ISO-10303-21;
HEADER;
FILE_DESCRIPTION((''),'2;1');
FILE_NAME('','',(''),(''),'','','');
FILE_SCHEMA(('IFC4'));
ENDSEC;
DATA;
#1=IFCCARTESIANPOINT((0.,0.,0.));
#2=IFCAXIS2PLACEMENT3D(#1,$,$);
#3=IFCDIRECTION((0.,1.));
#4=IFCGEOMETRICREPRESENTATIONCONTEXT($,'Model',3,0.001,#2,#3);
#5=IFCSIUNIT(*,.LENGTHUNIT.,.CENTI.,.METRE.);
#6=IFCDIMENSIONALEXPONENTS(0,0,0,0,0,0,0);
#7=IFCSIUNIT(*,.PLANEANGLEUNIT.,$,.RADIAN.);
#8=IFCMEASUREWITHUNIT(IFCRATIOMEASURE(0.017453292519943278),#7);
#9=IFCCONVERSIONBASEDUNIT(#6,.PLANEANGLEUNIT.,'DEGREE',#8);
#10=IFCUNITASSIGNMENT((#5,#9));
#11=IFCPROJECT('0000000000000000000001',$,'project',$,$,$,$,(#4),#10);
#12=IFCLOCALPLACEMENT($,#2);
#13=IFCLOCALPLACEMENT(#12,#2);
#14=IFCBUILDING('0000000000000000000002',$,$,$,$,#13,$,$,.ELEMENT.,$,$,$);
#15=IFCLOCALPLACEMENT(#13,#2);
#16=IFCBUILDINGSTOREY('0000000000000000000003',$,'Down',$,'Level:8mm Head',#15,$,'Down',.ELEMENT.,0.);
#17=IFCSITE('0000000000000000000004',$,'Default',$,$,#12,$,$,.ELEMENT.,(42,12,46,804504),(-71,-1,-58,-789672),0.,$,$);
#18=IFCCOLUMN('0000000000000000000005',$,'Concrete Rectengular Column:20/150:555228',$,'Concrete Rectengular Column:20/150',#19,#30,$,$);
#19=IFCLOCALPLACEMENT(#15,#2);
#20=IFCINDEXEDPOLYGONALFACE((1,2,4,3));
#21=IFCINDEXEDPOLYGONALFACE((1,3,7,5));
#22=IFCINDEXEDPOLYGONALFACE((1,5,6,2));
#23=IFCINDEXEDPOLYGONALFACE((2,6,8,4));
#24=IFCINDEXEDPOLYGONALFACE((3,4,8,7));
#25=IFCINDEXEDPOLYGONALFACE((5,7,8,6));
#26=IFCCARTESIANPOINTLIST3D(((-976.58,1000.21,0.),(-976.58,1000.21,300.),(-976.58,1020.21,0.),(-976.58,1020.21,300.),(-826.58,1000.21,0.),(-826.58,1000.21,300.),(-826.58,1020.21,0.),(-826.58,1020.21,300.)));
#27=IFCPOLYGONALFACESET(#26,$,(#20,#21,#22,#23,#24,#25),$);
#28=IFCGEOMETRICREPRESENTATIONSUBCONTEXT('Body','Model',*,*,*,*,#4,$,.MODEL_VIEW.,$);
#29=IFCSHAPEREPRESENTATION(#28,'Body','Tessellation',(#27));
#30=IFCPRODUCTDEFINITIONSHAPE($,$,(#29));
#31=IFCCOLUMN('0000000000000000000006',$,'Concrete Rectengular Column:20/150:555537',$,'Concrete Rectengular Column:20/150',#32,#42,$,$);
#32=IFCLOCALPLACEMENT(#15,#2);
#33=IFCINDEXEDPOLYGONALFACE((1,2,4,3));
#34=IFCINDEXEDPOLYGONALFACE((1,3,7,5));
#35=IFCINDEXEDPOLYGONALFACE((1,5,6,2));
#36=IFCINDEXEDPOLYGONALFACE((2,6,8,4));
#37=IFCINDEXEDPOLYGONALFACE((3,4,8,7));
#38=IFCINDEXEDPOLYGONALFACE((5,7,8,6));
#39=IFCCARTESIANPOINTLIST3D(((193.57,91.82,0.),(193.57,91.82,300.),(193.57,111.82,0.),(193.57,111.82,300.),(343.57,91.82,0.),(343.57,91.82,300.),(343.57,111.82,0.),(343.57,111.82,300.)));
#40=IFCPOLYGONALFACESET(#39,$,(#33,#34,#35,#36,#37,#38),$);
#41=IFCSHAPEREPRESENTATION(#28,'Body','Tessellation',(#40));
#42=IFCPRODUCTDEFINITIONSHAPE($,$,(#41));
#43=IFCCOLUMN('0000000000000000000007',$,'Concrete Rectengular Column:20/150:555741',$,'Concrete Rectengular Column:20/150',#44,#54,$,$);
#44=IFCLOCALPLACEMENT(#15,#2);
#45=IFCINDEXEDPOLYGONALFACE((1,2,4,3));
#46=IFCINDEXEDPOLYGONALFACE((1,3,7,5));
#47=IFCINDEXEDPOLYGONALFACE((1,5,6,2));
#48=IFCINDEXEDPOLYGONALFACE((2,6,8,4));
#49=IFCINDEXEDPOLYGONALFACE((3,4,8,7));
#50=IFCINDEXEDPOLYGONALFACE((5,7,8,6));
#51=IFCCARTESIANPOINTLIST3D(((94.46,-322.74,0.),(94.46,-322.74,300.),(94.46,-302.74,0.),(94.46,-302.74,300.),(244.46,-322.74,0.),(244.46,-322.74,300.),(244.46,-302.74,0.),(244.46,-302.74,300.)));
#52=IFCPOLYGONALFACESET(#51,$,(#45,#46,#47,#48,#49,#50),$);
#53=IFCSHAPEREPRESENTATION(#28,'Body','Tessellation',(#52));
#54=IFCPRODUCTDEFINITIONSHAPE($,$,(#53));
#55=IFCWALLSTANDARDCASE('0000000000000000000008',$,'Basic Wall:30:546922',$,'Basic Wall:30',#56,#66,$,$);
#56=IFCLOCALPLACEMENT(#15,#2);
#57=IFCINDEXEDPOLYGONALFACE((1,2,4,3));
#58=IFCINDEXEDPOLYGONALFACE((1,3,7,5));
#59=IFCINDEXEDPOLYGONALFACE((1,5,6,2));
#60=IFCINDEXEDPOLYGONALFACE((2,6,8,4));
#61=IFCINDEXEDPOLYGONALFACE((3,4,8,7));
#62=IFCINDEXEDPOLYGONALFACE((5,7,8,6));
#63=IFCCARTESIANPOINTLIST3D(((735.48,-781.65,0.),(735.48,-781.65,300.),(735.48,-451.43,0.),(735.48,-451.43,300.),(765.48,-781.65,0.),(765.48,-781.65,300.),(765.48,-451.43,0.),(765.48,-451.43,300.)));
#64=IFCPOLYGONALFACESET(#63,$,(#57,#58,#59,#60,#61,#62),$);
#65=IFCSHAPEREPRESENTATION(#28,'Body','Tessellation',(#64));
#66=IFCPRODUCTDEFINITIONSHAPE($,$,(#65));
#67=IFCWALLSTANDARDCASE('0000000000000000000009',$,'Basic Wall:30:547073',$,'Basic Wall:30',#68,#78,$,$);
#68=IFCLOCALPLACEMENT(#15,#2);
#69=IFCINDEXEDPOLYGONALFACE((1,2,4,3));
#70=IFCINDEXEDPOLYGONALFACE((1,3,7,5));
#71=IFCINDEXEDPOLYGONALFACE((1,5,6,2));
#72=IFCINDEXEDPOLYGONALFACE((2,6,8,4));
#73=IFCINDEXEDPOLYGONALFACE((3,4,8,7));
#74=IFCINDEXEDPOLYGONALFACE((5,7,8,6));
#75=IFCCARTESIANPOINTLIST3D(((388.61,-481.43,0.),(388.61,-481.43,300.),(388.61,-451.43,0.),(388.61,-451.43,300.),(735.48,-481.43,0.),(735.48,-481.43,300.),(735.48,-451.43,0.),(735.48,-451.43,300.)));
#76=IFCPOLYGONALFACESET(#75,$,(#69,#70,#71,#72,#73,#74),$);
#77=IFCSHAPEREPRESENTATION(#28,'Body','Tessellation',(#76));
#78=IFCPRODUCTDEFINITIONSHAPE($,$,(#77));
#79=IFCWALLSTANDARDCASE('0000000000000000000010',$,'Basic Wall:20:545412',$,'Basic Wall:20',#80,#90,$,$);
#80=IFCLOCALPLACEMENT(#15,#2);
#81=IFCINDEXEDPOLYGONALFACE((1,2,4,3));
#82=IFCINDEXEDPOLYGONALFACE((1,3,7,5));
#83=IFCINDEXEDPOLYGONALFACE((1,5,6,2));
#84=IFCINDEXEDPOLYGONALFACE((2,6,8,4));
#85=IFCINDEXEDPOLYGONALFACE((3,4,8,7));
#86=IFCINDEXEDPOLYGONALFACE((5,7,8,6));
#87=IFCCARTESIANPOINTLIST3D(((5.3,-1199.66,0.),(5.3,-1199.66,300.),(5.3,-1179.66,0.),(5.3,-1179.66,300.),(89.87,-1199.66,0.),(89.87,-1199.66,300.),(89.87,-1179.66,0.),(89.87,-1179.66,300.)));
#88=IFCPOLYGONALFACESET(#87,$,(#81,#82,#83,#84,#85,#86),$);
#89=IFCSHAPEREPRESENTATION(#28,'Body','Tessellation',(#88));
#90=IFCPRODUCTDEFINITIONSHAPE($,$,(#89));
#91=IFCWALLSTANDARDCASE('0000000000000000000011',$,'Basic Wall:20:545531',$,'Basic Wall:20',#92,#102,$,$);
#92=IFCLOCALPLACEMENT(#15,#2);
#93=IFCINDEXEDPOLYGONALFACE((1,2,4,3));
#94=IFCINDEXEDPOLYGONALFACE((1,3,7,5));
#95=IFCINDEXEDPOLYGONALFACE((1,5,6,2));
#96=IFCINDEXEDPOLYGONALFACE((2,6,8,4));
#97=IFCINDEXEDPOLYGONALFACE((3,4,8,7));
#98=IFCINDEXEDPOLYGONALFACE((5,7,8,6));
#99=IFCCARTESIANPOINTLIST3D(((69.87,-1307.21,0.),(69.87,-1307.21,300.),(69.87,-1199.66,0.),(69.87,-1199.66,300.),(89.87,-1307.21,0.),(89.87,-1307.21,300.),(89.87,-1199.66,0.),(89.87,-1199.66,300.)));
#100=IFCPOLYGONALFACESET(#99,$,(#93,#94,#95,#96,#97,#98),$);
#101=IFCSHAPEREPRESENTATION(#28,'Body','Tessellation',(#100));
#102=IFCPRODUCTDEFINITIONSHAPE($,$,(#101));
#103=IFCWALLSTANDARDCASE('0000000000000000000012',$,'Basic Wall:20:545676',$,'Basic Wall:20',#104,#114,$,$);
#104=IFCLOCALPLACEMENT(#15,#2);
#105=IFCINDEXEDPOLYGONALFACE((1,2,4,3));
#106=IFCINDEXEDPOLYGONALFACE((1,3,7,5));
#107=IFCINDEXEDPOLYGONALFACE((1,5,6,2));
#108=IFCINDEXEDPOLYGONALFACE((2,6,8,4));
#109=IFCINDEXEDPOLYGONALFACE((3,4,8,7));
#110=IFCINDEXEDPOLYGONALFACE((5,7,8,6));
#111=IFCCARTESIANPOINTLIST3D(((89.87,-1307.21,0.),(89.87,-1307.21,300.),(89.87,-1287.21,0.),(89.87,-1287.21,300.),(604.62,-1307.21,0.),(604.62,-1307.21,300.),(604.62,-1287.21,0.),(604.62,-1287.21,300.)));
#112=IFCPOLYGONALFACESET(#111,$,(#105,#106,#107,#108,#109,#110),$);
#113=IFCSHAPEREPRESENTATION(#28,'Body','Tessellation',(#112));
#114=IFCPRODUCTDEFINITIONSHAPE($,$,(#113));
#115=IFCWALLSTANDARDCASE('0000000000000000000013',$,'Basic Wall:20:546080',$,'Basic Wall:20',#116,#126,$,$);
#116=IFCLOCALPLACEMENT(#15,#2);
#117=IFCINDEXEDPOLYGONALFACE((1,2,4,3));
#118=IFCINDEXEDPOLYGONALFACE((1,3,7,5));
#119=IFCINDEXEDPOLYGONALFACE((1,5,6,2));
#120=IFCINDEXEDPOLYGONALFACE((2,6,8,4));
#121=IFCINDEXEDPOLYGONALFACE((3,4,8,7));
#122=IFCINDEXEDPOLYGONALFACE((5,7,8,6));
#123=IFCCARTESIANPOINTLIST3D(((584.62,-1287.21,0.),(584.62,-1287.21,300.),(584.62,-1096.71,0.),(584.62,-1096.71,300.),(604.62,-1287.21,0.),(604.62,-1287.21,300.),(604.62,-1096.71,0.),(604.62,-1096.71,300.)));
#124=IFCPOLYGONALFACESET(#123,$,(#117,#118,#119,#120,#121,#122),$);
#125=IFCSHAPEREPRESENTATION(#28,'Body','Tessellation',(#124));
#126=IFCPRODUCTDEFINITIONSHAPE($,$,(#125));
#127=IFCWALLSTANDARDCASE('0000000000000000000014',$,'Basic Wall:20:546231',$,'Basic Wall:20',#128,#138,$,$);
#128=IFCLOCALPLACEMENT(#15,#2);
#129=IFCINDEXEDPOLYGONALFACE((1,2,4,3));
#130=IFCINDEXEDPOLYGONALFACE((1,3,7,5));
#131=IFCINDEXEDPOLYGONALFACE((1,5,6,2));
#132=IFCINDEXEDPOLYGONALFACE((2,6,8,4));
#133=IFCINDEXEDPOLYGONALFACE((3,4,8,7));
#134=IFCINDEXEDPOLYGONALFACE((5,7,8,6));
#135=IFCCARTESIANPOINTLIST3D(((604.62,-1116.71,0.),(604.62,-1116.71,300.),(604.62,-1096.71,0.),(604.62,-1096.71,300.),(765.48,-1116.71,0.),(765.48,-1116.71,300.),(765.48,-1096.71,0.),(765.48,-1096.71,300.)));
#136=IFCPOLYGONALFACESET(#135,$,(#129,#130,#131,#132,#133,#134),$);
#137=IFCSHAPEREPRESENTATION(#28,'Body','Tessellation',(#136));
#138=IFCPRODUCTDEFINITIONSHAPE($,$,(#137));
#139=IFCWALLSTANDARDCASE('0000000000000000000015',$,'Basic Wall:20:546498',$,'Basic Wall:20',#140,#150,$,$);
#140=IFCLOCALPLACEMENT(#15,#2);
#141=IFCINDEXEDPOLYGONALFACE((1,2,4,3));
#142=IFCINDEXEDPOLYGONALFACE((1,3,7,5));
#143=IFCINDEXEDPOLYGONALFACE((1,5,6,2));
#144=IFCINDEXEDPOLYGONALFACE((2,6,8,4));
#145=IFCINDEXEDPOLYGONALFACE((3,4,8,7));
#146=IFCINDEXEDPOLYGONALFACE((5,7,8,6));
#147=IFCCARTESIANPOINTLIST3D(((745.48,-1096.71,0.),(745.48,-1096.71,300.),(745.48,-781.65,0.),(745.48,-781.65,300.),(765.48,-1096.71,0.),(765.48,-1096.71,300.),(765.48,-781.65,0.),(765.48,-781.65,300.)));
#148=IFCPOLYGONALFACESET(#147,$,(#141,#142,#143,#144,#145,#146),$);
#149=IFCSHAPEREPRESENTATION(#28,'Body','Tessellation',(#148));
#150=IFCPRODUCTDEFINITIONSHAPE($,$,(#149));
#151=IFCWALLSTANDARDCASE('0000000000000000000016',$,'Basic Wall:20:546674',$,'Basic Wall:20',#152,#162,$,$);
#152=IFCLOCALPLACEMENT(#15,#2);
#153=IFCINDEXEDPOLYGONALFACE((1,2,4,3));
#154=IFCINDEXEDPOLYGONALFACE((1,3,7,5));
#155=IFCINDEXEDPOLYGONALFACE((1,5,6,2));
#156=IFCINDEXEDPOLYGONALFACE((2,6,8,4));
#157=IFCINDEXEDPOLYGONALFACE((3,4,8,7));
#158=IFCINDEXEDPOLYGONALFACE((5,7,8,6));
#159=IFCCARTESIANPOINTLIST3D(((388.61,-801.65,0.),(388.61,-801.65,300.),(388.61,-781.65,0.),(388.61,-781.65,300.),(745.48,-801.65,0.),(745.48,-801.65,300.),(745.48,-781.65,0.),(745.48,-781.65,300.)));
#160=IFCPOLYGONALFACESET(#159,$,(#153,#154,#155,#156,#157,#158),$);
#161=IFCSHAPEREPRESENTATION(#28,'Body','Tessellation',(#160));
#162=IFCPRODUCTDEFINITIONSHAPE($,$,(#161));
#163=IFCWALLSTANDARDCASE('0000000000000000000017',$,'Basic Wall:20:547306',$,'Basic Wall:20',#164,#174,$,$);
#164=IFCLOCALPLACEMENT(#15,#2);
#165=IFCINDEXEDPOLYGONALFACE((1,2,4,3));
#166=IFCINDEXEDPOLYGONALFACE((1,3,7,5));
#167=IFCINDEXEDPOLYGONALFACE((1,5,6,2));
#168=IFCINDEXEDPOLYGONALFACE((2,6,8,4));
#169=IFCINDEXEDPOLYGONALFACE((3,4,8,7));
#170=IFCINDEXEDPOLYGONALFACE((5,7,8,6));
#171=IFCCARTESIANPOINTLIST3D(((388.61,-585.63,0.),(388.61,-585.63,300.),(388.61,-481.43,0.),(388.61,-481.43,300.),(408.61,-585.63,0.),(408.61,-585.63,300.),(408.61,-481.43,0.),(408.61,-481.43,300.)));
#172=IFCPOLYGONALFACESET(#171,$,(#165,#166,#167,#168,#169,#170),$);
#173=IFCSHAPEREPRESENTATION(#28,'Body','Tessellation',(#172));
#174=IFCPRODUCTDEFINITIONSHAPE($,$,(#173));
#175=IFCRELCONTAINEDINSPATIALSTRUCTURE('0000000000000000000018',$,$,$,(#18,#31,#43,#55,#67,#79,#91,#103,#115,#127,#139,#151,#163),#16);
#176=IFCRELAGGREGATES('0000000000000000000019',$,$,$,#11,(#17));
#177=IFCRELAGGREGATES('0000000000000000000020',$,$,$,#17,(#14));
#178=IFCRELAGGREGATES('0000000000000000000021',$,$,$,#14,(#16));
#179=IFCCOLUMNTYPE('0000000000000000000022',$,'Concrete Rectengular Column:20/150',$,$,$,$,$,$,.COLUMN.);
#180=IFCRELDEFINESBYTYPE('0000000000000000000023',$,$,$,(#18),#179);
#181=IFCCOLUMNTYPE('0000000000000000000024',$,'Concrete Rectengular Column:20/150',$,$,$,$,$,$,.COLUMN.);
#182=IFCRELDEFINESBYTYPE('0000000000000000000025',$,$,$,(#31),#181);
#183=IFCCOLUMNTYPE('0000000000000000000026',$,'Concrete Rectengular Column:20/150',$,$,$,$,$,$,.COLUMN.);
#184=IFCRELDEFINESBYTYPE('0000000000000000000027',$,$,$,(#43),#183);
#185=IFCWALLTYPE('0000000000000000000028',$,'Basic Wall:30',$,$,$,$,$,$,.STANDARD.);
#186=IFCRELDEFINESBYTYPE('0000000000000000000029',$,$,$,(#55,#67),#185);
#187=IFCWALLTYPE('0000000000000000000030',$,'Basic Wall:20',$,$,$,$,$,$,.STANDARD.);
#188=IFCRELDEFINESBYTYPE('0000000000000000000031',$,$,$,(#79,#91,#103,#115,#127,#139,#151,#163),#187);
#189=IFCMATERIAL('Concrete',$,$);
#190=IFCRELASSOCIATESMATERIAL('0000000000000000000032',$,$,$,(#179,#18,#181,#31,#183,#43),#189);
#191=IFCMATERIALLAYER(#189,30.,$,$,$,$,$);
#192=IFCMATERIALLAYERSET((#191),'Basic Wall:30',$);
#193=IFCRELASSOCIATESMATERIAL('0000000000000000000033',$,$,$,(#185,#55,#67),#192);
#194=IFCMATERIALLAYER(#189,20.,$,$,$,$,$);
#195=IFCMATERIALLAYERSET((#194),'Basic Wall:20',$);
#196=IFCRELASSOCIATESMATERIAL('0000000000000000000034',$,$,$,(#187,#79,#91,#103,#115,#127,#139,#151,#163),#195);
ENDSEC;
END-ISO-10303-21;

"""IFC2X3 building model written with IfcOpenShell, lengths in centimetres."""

from ifc_helpers import new_model, entity, si_unit, converted_unit, direction, frame, frame_2d, origin, place, context, subcontext, project, spatial, rectangle, extrude, source, transform, mapped, material, layer, layer_set, layer_usage, type_object, type_shapes, element, save


model = new_model("IFC2X3")

# Units and contexts
model_context = context("Model", 3, precision=0.001, world=origin(), true_north=direction((0.0, 1.0)))
body_context = subcontext(model_context, "Body", "Model", "MODEL_VIEW")
ifc_project = project(units=[si_unit("LENGTHUNIT", "METRE", prefix="CENTI"), converted_unit("PLANEANGLEUNIT", "DEGREE", entity("IfcRatioMeasure", 0.017453292519943278), si_unit("PLANEANGLEUNIT", "RADIAN"), dimensions=[0, 0, 0, 0, 0, 0, 0])], contexts=[model_context])

# Site, building, storey
site_placement = place(None, origin())
site = spatial("IfcSite", under=ifc_project, at=site_placement, Name="Default", CompositionType="ELEMENT", RefLatitude=(42, 12, 46, 804504), RefLongitude=(-71, -1, -58, -789672), RefElevation=0.0)
building_placement = place(site_placement, origin())
building = spatial("IfcBuilding", under=site, at=building_placement, CompositionType="ELEMENT")
storey_placement = place(building_placement, origin())
storey = spatial("IfcBuildingStorey", under=building, at=storey_placement, Name="Down", ObjectType="Level:8mm Head", LongName="Down", CompositionType="ELEMENT", Elevation=0.0)

# Columns
ifc_material = material(Name="Concrete")
column_type_1 = type_object("IfcColumnType", Name="Concrete Rectengular Column:20/150", PredefinedType="COLUMN", material=ifc_material)
shared_shape_1 = source(origin(), body_context, "Body", "SweptSolid", [
    extrude(rectangle(XDim=20.0, YDim=150.0, at=frame_2d((0.0, 0.0), x_axis=(1.0, 0.0))), frame((-901.58, 1010.21, 0.0), z_axis=(0.0, 0.0, 1.0), x_axis=(0.0, -1.0, 0.0)), (0.0, 0.0, 1.0), 300.0),
])
type_shapes(column_type_1, [shared_shape_1])
column_1_placement = place(storey_placement, origin())
element("IfcColumn", 1, at=column_1_placement, inside=storey, type_object=column_type_1, material=ifc_material, Name="Concrete Rectengular Column:20/150:555228", ObjectType="Concrete Rectengular Column:20/150", context=body_context, shape_type="MappedRepresentation", body=[
    mapped(shared_shape_1, transform((0.0, 0.0, 0.0), scale=1.0)),
])
column_type_2 = type_object("IfcColumnType", Name="Concrete Rectengular Column:20/150", PredefinedType="COLUMN", material=ifc_material)
shared_shape_2 = source(origin(), body_context, "Body", "SweptSolid", [
    extrude(rectangle(XDim=20.0, YDim=150.0, at=frame_2d((0.0, 0.0), x_axis=(1.0, 0.0))), frame((268.57, 101.82, 0.0), z_axis=(0.0, 0.0, 1.0), x_axis=(0.0, -1.0, 0.0)), (0.0, 0.0, 1.0), 300.0),
])
type_shapes(column_type_2, [shared_shape_2])
column_2_placement = place(storey_placement, origin())
element("IfcColumn", 2, at=column_2_placement, inside=storey, type_object=column_type_2, material=ifc_material, Name="Concrete Rectengular Column:20/150:555537", ObjectType="Concrete Rectengular Column:20/150", context=body_context, shape_type="MappedRepresentation", body=[
    mapped(shared_shape_2, transform((0.0, 0.0, 0.0), scale=1.0)),
])
column_type_3 = type_object("IfcColumnType", Name="Concrete Rectengular Column:20/150", PredefinedType="COLUMN", material=ifc_material)
shared_shape_3 = source(origin(), body_context, "Body", "SweptSolid", [
    extrude(rectangle(XDim=20.0, YDim=150.0, at=frame_2d((0.0, 0.0), x_axis=(1.0, 0.0))), frame((169.46, -312.74, 0.0), z_axis=(0.0, 0.0, 1.0), x_axis=(0.0, -1.0, 0.0)), (0.0, 0.0, 1.0), 300.0),
])
type_shapes(column_type_3, [shared_shape_3])
column_3_placement = place(storey_placement, origin())
element("IfcColumn", 3, at=column_3_placement, inside=storey, type_object=column_type_3, material=ifc_material, Name="Concrete Rectengular Column:20/150:555741", ObjectType="Concrete Rectengular Column:20/150", context=body_context, shape_type="MappedRepresentation", body=[
    mapped(shared_shape_3, transform((0.0, 0.0, 0.0), scale=1.0)),
])

# Walls
ifc_layer_1 = layer(ifc_material, 30.0)
ifc_layer_set_1 = layer_set([ifc_layer_1], Name="Basic Wall:30")
ifc_layer_usage_1 = layer_usage(ifc_layer_set_1, "AXIS2", "POSITIVE", -15.0)
wall_type_1 = type_object("IfcWallType", Name="Basic Wall:30", PredefinedType="STANDARD", material=ifc_layer_set_1)
wall_1_placement = place(storey_placement, frame((750.48, -781.65, 0.0), z_axis=(0.0, 0.0, 1.0), x_axis=(0.0, 1.0, 0.0)))
element("IfcWallStandardCase", 4, at=wall_1_placement, inside=storey, type_object=wall_type_1, material=ifc_layer_usage_1, Name="Basic Wall:30:546922", ObjectType="Basic Wall:30", context=body_context, shape_type="SweptSolid", body=[
    extrude(rectangle(XDim=330.22, YDim=30.0, at=frame_2d((165.11, 0.0), x_axis=(-1.0, 0.0))), origin(), (0.0, 0.0, 1.0), 300.0),
])
ifc_layer_usage_2 = layer_usage(ifc_layer_set_1, "AXIS2", "POSITIVE", -15.0)
wall_2_placement = place(storey_placement, frame((735.48, -466.43, 0.0), z_axis=(0.0, 0.0, 1.0), x_axis=(-1.0, 0.0, 0.0)))
element("IfcWallStandardCase", 5, at=wall_2_placement, inside=storey, type_object=wall_type_1, material=ifc_layer_usage_2, Name="Basic Wall:30:547073", ObjectType="Basic Wall:30", context=body_context, shape_type="SweptSolid", body=[
    extrude(rectangle(XDim=346.87, YDim=30.0, at=frame_2d((173.44, 0.0), x_axis=(-1.0, 0.0))), origin(), (0.0, 0.0, 1.0), 300.0),
])
ifc_layer_2 = layer(ifc_material, 20.0)
ifc_layer_set_2 = layer_set([ifc_layer_2], Name="Basic Wall:20")
ifc_layer_usage_3 = layer_usage(ifc_layer_set_2, "AXIS2", "POSITIVE", -10.0)
wall_type_2 = type_object("IfcWallType", Name="Basic Wall:20", PredefinedType="STANDARD", material=ifc_layer_set_2)
wall_3_placement = place(storey_placement, frame((5.3, -1189.66, 0.0)))
element("IfcWallStandardCase", 6, at=wall_3_placement, inside=storey, type_object=wall_type_2, material=ifc_layer_usage_3, Name="Basic Wall:20:545412", ObjectType="Basic Wall:20", context=body_context, shape_type="SweptSolid", body=[
    extrude(rectangle(XDim=84.57, YDim=20.0, at=frame_2d((42.28, 0.0), x_axis=(-1.0, 0.0))), origin(), (0.0, 0.0, 1.0), 300.0),
])
ifc_layer_usage_4 = layer_usage(ifc_layer_set_2, "AXIS2", "NEGATIVE", 10.0)
wall_4_placement = place(storey_placement, frame((79.87, -1199.66, 0.0), z_axis=(0.0, 0.0, 1.0), x_axis=(0.0, -1.0, 0.0)))
element("IfcWallStandardCase", 7, at=wall_4_placement, inside=storey, type_object=wall_type_2, material=ifc_layer_usage_4, Name="Basic Wall:20:545531", ObjectType="Basic Wall:20", context=body_context, shape_type="SweptSolid", body=[
    extrude(rectangle(XDim=107.55, YDim=20.0, at=frame_2d((53.77, 0.0), x_axis=(-1.0, 0.0))), origin(), (0.0, 0.0, 1.0), 300.0),
])
ifc_layer_usage_5 = layer_usage(ifc_layer_set_2, "AXIS2", "POSITIVE", -10.0)
wall_5_placement = place(storey_placement, frame((89.87, -1297.21, 0.0)))
element("IfcWallStandardCase", 8, at=wall_5_placement, inside=storey, type_object=wall_type_2, material=ifc_layer_usage_5, Name="Basic Wall:20:545676", ObjectType="Basic Wall:20", context=body_context, shape_type="SweptSolid", body=[
    extrude(rectangle(XDim=514.75, YDim=20.0, at=frame_2d((257.38, 0.0), x_axis=(-1.0, 0.0))), origin(), (0.0, 0.0, 1.0), 300.0),
])
ifc_layer_usage_6 = layer_usage(ifc_layer_set_2, "AXIS2", "POSITIVE", -10.0)
wall_6_placement = place(storey_placement, frame((594.62, -1287.21, 0.0), z_axis=(0.0, 0.0, 1.0), x_axis=(0.0, 1.0, 0.0)))
element("IfcWallStandardCase", 9, at=wall_6_placement, inside=storey, type_object=wall_type_2, material=ifc_layer_usage_6, Name="Basic Wall:20:546080", ObjectType="Basic Wall:20", context=body_context, shape_type="SweptSolid", body=[
    extrude(rectangle(XDim=190.5, YDim=20.0, at=frame_2d((95.25, 0.0), x_axis=(-1.0, 0.0))), origin(), (0.0, 0.0, 1.0), 300.0),
])
ifc_layer_usage_7 = layer_usage(ifc_layer_set_2, "AXIS2", "NEGATIVE", 10.0)
wall_7_placement = place(storey_placement, frame((604.62, -1106.71, 0.0)))
element("IfcWallStandardCase", 10, at=wall_7_placement, inside=storey, type_object=wall_type_2, material=ifc_layer_usage_7, Name="Basic Wall:20:546231", ObjectType="Basic Wall:20", context=body_context, shape_type="SweptSolid", body=[
    extrude(rectangle(XDim=160.86, YDim=20.0, at=frame_2d((80.43, 0.0), x_axis=(-1.0, 0.0))), origin(), (0.0, 0.0, 1.0), 300.0),
])
ifc_layer_usage_8 = layer_usage(ifc_layer_set_2, "AXIS2", "POSITIVE", -10.0)
wall_8_placement = place(storey_placement, frame((755.48, -1096.71, 0.0), z_axis=(0.0, 0.0, 1.0), x_axis=(0.0, 1.0, 0.0)))
element("IfcWallStandardCase", 11, at=wall_8_placement, inside=storey, type_object=wall_type_2, material=ifc_layer_usage_8, Name="Basic Wall:20:546498", ObjectType="Basic Wall:20", context=body_context, shape_type="SweptSolid", body=[
    extrude(rectangle(XDim=315.06, YDim=20.0, at=frame_2d((157.53, 0.0), x_axis=(-1.0, 0.0))), origin(), (0.0, 0.0, 1.0), 300.0),
])
ifc_layer_usage_9 = layer_usage(ifc_layer_set_2, "AXIS2", "POSITIVE", -10.0)
wall_9_placement = place(storey_placement, frame((388.61, -791.65, 0.0)))
element("IfcWallStandardCase", 12, at=wall_9_placement, inside=storey, type_object=wall_type_2, material=ifc_layer_usage_9, Name="Basic Wall:20:546674", ObjectType="Basic Wall:20", context=body_context, shape_type="SweptSolid", body=[
    extrude(rectangle(XDim=356.87, YDim=20.0, at=frame_2d((178.44, 0.0), x_axis=(-1.0, 0.0))), origin(), (0.0, 0.0, 1.0), 300.0),
])
ifc_layer_usage_10 = layer_usage(ifc_layer_set_2, "AXIS2", "POSITIVE", -10.0)
wall_10_placement = place(storey_placement, frame((398.61, -481.43, 0.0), z_axis=(0.0, 0.0, 1.0), x_axis=(0.0, -1.0, 0.0)))
element("IfcWallStandardCase", 13, at=wall_10_placement, inside=storey, type_object=wall_type_2, material=ifc_layer_usage_10, Name="Basic Wall:20:547306", ObjectType="Basic Wall:20", context=body_context, shape_type="SweptSolid", body=[
    extrude(rectangle(XDim=104.2, YDim=20.0, at=frame_2d((52.1, 0.0), x_axis=(-1.0, 0.0))), origin(), (0.0, 0.0, 1.0), 300.0),
])

save(model, "model.ifc")
